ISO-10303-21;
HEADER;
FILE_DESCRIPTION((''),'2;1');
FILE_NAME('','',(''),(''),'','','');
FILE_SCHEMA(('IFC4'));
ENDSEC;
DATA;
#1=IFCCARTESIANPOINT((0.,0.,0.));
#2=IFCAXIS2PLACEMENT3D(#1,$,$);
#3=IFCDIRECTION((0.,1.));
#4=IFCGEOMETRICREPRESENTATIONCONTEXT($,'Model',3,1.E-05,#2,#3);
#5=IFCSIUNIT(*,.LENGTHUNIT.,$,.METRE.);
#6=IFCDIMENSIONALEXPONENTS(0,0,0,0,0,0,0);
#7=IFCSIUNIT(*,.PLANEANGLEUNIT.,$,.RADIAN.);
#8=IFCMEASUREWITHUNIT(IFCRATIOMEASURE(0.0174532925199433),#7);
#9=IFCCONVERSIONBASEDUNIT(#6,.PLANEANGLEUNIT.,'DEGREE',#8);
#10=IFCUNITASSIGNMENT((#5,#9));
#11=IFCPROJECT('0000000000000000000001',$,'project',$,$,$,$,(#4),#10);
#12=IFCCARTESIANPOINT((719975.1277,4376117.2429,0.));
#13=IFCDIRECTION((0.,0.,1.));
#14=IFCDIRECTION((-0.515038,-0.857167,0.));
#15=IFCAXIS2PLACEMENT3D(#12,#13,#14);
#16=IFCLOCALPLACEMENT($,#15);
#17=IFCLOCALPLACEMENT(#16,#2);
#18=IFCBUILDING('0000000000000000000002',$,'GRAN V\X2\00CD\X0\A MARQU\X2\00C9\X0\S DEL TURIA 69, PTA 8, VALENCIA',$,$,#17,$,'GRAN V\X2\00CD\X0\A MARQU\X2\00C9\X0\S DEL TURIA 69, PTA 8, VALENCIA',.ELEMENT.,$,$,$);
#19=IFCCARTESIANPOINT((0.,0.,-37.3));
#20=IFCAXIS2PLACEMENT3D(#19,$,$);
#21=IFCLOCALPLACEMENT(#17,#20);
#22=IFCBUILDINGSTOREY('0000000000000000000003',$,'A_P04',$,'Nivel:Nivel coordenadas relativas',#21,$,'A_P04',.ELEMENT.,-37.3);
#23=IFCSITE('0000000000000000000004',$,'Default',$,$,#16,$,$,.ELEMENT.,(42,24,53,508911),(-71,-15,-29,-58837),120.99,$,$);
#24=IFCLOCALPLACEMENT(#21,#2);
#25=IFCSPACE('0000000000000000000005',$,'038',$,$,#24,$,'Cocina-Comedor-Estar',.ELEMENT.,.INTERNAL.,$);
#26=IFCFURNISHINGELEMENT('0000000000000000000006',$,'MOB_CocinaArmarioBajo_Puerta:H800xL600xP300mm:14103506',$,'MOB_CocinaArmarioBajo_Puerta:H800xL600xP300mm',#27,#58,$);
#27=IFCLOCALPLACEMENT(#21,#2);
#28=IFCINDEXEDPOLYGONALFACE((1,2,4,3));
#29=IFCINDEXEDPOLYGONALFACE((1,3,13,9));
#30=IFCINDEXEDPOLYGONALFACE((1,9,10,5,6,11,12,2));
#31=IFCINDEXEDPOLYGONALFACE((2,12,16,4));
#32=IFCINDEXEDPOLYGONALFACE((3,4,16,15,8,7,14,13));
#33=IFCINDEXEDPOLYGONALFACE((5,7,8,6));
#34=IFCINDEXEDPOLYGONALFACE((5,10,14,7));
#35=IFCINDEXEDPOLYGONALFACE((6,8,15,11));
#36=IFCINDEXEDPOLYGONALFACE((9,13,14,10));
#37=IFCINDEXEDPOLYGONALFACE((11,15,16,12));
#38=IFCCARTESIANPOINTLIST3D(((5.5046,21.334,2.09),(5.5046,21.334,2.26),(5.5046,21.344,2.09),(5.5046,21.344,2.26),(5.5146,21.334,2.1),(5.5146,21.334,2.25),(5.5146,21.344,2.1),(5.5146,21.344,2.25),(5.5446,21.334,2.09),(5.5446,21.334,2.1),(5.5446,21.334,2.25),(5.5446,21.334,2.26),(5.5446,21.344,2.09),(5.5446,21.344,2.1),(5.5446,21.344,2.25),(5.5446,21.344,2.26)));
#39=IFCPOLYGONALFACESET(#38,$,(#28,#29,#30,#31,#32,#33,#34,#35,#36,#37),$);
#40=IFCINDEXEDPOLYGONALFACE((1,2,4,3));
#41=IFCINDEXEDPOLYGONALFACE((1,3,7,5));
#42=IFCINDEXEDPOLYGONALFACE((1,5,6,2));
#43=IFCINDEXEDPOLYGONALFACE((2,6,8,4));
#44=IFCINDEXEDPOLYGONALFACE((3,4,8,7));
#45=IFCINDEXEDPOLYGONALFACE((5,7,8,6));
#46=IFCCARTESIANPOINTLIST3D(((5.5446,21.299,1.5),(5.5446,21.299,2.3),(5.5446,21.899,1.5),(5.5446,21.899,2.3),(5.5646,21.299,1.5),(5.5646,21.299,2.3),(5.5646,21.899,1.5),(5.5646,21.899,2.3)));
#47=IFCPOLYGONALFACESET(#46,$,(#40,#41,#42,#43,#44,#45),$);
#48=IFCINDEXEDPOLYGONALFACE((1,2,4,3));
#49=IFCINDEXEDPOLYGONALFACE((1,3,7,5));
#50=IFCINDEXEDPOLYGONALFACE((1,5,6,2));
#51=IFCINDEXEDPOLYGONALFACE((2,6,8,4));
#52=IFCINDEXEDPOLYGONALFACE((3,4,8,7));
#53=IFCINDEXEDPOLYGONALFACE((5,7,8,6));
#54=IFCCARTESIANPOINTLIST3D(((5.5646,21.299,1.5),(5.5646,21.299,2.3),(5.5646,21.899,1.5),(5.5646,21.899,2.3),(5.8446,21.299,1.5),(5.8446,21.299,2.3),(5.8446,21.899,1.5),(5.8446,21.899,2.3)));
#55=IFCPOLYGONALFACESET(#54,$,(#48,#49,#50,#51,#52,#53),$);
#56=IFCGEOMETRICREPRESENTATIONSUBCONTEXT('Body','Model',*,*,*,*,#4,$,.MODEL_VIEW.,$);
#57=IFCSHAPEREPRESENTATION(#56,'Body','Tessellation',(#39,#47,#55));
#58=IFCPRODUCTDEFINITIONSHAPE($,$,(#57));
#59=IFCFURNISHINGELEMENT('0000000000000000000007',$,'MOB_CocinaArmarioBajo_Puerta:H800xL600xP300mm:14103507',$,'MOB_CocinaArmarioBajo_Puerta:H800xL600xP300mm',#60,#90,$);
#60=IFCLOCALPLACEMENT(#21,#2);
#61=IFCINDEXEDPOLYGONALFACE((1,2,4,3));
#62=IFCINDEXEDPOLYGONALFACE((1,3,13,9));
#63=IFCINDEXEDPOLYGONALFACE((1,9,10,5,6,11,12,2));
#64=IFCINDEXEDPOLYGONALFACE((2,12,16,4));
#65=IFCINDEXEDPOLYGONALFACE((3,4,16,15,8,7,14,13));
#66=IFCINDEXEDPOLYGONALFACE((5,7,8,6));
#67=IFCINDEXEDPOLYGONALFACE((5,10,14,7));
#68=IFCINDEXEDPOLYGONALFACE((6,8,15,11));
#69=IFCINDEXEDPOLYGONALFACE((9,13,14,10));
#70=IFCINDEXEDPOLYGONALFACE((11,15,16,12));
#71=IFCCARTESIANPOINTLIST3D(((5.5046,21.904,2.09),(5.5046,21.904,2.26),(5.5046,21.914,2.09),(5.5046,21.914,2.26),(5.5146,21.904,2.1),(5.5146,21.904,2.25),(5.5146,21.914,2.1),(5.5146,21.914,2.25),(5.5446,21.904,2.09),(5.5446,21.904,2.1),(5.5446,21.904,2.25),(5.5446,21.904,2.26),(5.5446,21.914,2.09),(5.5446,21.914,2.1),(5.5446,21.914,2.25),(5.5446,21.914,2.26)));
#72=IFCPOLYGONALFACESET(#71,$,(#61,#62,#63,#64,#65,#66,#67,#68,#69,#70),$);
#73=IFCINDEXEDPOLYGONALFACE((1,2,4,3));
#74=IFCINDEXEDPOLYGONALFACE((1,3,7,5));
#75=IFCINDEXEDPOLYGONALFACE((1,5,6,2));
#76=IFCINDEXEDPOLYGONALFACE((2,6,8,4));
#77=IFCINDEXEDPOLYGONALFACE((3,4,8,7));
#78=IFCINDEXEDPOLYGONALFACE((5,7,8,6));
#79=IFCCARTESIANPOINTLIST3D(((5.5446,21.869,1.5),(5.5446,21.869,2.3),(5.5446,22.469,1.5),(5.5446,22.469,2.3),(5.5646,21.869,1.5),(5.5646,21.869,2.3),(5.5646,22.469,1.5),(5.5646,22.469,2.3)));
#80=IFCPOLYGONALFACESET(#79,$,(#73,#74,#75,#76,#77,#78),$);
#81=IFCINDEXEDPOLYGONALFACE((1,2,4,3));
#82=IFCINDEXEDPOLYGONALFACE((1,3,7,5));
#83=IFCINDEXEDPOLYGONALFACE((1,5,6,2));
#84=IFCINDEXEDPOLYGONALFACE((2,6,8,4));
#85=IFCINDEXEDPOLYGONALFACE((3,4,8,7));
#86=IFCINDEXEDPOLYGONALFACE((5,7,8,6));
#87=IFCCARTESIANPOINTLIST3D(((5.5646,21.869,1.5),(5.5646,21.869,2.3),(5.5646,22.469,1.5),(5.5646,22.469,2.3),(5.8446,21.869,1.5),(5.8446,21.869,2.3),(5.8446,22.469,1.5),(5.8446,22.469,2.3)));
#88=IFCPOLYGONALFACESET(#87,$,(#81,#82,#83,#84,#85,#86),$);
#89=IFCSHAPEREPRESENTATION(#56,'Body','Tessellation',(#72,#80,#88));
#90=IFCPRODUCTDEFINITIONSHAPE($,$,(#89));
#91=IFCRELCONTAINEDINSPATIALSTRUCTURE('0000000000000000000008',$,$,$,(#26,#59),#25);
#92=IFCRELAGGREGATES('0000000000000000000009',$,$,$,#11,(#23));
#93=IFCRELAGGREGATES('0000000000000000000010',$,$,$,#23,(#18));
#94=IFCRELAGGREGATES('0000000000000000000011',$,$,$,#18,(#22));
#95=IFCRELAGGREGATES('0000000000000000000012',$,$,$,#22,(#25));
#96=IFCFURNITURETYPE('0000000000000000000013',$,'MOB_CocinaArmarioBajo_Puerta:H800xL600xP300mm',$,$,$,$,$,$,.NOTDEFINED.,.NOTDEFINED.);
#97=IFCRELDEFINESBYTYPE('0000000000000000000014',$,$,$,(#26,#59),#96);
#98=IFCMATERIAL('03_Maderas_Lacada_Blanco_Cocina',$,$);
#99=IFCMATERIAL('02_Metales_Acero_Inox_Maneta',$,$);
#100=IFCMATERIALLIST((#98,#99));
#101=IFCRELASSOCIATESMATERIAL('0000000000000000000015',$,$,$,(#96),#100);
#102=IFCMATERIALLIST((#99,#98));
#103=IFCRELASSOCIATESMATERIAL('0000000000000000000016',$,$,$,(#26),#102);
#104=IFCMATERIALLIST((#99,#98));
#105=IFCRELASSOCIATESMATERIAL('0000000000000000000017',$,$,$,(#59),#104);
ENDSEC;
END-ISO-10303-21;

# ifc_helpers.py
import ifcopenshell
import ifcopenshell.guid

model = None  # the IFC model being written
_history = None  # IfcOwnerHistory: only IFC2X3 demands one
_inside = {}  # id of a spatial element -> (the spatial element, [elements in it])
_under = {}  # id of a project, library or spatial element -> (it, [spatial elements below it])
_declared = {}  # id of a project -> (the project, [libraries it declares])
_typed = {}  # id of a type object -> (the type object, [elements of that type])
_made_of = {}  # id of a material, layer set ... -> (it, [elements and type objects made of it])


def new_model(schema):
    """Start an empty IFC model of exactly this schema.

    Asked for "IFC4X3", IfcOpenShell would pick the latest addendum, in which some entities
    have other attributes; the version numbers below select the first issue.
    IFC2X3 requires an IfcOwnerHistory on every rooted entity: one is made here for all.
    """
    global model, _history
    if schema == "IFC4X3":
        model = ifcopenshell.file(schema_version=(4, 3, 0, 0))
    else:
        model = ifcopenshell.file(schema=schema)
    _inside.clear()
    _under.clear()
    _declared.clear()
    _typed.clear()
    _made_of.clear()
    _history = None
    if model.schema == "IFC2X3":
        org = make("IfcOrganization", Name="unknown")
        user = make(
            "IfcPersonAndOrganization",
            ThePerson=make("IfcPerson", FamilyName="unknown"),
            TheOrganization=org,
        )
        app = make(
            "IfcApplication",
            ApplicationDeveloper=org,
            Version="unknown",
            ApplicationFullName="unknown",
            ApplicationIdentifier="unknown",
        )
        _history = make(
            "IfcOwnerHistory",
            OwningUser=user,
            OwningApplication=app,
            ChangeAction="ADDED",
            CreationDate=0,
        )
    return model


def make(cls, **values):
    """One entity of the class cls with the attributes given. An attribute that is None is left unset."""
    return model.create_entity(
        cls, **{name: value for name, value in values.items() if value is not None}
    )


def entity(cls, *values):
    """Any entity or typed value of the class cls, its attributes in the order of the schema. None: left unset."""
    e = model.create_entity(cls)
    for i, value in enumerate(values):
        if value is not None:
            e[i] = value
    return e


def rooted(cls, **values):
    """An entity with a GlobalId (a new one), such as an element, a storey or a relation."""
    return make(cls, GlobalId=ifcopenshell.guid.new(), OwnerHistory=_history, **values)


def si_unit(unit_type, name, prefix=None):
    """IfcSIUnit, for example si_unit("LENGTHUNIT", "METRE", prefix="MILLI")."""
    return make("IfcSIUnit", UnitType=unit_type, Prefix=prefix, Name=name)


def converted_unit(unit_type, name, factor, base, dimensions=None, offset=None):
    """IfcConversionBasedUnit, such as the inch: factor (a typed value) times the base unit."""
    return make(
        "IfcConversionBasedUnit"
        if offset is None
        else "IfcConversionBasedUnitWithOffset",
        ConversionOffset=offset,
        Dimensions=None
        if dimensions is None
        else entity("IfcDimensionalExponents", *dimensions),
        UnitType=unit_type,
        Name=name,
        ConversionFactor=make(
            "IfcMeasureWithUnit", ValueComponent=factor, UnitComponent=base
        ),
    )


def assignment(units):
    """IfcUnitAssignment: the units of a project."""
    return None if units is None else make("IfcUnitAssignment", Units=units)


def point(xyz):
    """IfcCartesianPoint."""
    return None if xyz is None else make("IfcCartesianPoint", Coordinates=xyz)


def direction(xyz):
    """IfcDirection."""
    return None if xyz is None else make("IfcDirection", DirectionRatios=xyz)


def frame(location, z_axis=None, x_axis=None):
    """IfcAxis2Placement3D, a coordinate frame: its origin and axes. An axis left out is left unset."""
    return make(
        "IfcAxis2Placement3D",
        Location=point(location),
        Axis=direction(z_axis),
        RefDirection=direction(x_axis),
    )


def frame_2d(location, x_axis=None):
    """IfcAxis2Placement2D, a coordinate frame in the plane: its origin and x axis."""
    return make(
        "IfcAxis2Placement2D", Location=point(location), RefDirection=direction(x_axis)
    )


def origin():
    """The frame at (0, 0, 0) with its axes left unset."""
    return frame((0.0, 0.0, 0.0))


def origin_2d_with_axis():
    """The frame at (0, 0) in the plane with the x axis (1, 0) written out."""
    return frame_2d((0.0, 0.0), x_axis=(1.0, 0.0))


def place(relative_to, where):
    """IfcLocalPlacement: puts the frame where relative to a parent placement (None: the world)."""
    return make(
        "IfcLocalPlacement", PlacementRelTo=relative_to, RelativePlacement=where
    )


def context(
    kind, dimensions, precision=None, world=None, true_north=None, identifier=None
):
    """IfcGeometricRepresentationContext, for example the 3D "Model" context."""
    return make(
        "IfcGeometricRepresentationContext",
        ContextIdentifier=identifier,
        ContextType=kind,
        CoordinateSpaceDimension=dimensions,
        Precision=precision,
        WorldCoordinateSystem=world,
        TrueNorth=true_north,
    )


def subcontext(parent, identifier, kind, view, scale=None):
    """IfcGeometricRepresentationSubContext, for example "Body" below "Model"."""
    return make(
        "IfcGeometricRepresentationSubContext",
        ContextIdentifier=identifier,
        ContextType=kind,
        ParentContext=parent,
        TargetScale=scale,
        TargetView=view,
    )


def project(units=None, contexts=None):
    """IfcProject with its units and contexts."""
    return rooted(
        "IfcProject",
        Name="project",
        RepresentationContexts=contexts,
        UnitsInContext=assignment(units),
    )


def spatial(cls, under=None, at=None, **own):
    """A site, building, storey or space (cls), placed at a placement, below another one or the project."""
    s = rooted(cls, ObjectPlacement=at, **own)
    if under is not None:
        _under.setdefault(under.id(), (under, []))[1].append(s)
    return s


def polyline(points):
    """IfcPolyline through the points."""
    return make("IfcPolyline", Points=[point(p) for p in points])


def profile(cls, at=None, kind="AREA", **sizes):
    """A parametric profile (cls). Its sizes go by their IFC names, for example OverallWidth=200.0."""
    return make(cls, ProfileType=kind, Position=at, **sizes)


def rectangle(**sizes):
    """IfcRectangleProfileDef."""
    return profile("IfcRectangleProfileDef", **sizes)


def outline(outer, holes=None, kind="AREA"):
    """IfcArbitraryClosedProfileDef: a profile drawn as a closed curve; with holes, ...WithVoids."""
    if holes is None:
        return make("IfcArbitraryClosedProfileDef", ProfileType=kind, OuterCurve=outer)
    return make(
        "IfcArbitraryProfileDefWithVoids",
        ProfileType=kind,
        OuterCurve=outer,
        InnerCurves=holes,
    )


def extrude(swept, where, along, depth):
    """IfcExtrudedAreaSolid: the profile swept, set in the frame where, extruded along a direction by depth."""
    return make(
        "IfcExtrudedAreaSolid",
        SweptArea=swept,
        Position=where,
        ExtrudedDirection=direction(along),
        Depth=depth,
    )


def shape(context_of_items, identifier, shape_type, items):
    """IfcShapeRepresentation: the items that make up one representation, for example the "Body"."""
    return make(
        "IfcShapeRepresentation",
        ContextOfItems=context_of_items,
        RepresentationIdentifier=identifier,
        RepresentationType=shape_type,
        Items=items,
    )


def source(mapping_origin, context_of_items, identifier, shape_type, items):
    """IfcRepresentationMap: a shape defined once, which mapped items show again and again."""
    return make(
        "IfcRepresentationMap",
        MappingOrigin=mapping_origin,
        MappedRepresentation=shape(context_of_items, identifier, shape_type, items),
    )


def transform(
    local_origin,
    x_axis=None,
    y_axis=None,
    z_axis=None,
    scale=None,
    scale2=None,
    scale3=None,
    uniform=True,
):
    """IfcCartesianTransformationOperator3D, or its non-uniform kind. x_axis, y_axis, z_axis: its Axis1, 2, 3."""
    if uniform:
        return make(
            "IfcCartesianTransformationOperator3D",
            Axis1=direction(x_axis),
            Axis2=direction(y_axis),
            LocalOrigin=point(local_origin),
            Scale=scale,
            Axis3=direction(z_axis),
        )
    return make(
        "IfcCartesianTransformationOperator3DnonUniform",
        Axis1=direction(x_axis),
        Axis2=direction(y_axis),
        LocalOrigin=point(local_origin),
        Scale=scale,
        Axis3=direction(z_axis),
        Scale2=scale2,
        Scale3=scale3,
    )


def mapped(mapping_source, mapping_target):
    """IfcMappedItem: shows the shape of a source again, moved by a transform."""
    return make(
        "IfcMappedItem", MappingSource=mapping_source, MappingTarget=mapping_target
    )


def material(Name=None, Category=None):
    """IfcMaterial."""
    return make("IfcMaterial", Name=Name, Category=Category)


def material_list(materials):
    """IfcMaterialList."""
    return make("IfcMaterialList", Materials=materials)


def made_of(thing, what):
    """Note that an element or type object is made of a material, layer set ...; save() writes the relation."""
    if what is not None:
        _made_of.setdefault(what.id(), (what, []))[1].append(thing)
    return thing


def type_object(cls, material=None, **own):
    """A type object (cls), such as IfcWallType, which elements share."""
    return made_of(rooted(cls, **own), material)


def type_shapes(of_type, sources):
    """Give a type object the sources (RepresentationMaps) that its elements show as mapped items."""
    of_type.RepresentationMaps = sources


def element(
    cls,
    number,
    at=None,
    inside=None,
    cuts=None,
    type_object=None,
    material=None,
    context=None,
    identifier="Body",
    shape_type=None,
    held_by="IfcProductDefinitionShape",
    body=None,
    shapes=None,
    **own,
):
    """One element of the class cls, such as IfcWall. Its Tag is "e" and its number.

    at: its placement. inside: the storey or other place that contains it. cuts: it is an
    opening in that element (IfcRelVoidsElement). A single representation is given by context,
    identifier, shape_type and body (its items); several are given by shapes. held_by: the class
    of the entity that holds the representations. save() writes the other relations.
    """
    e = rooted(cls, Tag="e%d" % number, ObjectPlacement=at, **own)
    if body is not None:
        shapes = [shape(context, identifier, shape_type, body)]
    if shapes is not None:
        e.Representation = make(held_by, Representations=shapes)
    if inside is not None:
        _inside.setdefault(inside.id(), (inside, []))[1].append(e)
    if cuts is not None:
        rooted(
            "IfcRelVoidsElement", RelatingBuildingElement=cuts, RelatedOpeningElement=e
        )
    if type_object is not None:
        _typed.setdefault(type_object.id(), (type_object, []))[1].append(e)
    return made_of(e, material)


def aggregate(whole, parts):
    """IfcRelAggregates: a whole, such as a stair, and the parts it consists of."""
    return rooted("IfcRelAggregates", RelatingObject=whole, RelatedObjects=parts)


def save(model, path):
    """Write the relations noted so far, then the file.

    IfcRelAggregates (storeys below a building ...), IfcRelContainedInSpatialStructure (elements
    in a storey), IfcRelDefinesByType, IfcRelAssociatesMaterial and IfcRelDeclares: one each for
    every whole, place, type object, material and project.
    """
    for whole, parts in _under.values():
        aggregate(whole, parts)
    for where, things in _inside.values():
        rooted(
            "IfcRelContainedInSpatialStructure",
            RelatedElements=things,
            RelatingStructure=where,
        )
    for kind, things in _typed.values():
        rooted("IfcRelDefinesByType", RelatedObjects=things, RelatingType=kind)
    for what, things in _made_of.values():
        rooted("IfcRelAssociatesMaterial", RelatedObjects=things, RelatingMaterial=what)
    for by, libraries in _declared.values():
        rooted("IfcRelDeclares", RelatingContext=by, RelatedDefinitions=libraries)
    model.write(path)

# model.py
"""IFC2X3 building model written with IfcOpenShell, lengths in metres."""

from ifc_helpers import new_model, entity, si_unit, converted_unit, direction, frame, frame_2d, origin, origin_2d_with_axis, place, context, subcontext, project, spatial, polyline, rectangle, outline, extrude, source, transform, mapped, material, material_list, type_object, type_shapes, element, save


model = new_model("IFC2X3")

# Units and contexts
model_context = context("Model", 3, precision=1e-05, world=origin(), true_north=direction((0.0, 1.0)))
body_context = subcontext(model_context, "Body", "Model", "MODEL_VIEW")
ifc_project = project(units=[si_unit("LENGTHUNIT", "METRE"), converted_unit("PLANEANGLEUNIT", "DEGREE", entity("IfcRatioMeasure", 0.0174532925199433), si_unit("PLANEANGLEUNIT", "RADIAN"), dimensions=[0, 0, 0, 0, 0, 0, 0])], contexts=[model_context])

# Site, building, storey
site_placement = place(None, frame((719975.1277, 4376117.2429, 0.0), z_axis=(0.0, 0.0, 1.0), x_axis=(-0.515038, -0.857167, 0.0)))
site = spatial("IfcSite", under=ifc_project, at=site_placement, Name="Default", CompositionType="ELEMENT", RefLatitude=(42, 24, 53, 508911), RefLongitude=(-71, -15, -29, -58837), RefElevation=120.99)
building_placement = place(site_placement, origin())
building = spatial("IfcBuilding", under=site, at=building_placement, Name="GRAN VÍA MARQUÉS DEL TURIA 69, PTA 8, VALENCIA", LongName="GRAN VÍA MARQUÉS DEL TURIA 69, PTA 8, VALENCIA", CompositionType="ELEMENT")
storey_placement = place(building_placement, frame((0.0, 0.0, -37.3)))
storey = spatial("IfcBuildingStorey", under=building, at=storey_placement, Name="A_P04", ObjectType="Nivel:Nivel coordenadas relativas", LongName="A_P04", CompositionType="ELEMENT", Elevation=-37.3)

# Shared definitions
ifc_material_1 = material(Name="02_Metales_Acero_Inox_Maneta")
ifc_material_2 = material(Name="03_Maderas_Lacada_Blanco_Cocina")

# Shared definitions
space_1_placement = place(storey_placement, origin())
space_1 = spatial("IfcSpace", under=storey, at=space_1_placement, Name="038", LongName="Cocina-Comedor-Estar", CompositionType="ELEMENT", InteriorOrExteriorSpace="INTERNAL")

# Furnishing elements
ifc_material_list_1 = material_list([ifc_material_2, ifc_material_1])
furniture_type_1 = type_object("IfcFurnitureType", Name="MOB_CocinaArmarioBajo_Puerta:H800xL600xP300mm", material=ifc_material_list_1)
shared_shape_1 = source(origin(), body_context, "Body", "SweptSolid", [
    extrude(outline(polyline([(0.075, -0.0175), (0.085, -0.0175), (0.085, 0.0225), (-0.085, 0.0225), (-0.085, -0.0175), (-0.075, -0.0175), (-0.075, 0.0125), (0.075, 0.0125), (0.075, -0.0175)])), frame((-0.265, 0.3175, 0.675), z_axis=(1.0, 0.0, 0.0), x_axis=(0.0, 0.0, -1.0)), (0.0, 0.0, 1.0), 0.01),
    extrude(rectangle(XDim=0.02, YDim=0.6, at=frame_2d((0.0, 0.0), x_axis=(1.0, 0.0))), frame((0.0, 0.29, 0.0), z_axis=(0.0, 0.0, 1.0), x_axis=(0.0, -1.0, 0.0)), (0.0, 0.0, 1.0), 0.8),
    extrude(rectangle(XDim=0.6, YDim=0.28, at=origin_2d_with_axis()), frame((0.0, 0.14, 0.0)), (0.0, 0.0, 1.0), 0.8),
])
type_shapes(furniture_type_1, [shared_shape_1])
ifc_material_list_2 = material_list([ifc_material_1, ifc_material_2])
furnishing_1_placement = place(space_1_placement, frame((5.8446, 21.599, 1.5), z_axis=(0.0, 0.0, 1.0), x_axis=(0.0, 1.0, 0.0)))
element("IfcFurnishingElement", 1, at=furnishing_1_placement, inside=space_1, type_object=furniture_type_1, material=ifc_material_list_2, Name="MOB_CocinaArmarioBajo_Puerta:H800xL600xP300mm:14103506", ObjectType="MOB_CocinaArmarioBajo_Puerta:H800xL600xP300mm", context=body_context, shape_type="MappedRepresentation", body=[
    mapped(shared_shape_1, transform((0.0, 0.0, 0.0), scale=1.0)),
])
ifc_material_list_3 = material_list([ifc_material_1, ifc_material_2])
furnishing_2_placement = place(space_1_placement, frame((5.8446, 22.169, 1.5), z_axis=(0.0, 0.0, 1.0), x_axis=(0.0, 1.0, 0.0)))
element("IfcFurnishingElement", 2, at=furnishing_2_placement, inside=space_1, type_object=furniture_type_1, material=ifc_material_list_3, Name="MOB_CocinaArmarioBajo_Puerta:H800xL600xP300mm:14103507", ObjectType="MOB_CocinaArmarioBajo_Puerta:H800xL600xP300mm", context=body_context, shape_type="MappedRepresentation", body=[
    mapped(shared_shape_1, transform((0.0, 0.0, 0.0), scale=1.0)),
])

save(model, "model.ifc")
